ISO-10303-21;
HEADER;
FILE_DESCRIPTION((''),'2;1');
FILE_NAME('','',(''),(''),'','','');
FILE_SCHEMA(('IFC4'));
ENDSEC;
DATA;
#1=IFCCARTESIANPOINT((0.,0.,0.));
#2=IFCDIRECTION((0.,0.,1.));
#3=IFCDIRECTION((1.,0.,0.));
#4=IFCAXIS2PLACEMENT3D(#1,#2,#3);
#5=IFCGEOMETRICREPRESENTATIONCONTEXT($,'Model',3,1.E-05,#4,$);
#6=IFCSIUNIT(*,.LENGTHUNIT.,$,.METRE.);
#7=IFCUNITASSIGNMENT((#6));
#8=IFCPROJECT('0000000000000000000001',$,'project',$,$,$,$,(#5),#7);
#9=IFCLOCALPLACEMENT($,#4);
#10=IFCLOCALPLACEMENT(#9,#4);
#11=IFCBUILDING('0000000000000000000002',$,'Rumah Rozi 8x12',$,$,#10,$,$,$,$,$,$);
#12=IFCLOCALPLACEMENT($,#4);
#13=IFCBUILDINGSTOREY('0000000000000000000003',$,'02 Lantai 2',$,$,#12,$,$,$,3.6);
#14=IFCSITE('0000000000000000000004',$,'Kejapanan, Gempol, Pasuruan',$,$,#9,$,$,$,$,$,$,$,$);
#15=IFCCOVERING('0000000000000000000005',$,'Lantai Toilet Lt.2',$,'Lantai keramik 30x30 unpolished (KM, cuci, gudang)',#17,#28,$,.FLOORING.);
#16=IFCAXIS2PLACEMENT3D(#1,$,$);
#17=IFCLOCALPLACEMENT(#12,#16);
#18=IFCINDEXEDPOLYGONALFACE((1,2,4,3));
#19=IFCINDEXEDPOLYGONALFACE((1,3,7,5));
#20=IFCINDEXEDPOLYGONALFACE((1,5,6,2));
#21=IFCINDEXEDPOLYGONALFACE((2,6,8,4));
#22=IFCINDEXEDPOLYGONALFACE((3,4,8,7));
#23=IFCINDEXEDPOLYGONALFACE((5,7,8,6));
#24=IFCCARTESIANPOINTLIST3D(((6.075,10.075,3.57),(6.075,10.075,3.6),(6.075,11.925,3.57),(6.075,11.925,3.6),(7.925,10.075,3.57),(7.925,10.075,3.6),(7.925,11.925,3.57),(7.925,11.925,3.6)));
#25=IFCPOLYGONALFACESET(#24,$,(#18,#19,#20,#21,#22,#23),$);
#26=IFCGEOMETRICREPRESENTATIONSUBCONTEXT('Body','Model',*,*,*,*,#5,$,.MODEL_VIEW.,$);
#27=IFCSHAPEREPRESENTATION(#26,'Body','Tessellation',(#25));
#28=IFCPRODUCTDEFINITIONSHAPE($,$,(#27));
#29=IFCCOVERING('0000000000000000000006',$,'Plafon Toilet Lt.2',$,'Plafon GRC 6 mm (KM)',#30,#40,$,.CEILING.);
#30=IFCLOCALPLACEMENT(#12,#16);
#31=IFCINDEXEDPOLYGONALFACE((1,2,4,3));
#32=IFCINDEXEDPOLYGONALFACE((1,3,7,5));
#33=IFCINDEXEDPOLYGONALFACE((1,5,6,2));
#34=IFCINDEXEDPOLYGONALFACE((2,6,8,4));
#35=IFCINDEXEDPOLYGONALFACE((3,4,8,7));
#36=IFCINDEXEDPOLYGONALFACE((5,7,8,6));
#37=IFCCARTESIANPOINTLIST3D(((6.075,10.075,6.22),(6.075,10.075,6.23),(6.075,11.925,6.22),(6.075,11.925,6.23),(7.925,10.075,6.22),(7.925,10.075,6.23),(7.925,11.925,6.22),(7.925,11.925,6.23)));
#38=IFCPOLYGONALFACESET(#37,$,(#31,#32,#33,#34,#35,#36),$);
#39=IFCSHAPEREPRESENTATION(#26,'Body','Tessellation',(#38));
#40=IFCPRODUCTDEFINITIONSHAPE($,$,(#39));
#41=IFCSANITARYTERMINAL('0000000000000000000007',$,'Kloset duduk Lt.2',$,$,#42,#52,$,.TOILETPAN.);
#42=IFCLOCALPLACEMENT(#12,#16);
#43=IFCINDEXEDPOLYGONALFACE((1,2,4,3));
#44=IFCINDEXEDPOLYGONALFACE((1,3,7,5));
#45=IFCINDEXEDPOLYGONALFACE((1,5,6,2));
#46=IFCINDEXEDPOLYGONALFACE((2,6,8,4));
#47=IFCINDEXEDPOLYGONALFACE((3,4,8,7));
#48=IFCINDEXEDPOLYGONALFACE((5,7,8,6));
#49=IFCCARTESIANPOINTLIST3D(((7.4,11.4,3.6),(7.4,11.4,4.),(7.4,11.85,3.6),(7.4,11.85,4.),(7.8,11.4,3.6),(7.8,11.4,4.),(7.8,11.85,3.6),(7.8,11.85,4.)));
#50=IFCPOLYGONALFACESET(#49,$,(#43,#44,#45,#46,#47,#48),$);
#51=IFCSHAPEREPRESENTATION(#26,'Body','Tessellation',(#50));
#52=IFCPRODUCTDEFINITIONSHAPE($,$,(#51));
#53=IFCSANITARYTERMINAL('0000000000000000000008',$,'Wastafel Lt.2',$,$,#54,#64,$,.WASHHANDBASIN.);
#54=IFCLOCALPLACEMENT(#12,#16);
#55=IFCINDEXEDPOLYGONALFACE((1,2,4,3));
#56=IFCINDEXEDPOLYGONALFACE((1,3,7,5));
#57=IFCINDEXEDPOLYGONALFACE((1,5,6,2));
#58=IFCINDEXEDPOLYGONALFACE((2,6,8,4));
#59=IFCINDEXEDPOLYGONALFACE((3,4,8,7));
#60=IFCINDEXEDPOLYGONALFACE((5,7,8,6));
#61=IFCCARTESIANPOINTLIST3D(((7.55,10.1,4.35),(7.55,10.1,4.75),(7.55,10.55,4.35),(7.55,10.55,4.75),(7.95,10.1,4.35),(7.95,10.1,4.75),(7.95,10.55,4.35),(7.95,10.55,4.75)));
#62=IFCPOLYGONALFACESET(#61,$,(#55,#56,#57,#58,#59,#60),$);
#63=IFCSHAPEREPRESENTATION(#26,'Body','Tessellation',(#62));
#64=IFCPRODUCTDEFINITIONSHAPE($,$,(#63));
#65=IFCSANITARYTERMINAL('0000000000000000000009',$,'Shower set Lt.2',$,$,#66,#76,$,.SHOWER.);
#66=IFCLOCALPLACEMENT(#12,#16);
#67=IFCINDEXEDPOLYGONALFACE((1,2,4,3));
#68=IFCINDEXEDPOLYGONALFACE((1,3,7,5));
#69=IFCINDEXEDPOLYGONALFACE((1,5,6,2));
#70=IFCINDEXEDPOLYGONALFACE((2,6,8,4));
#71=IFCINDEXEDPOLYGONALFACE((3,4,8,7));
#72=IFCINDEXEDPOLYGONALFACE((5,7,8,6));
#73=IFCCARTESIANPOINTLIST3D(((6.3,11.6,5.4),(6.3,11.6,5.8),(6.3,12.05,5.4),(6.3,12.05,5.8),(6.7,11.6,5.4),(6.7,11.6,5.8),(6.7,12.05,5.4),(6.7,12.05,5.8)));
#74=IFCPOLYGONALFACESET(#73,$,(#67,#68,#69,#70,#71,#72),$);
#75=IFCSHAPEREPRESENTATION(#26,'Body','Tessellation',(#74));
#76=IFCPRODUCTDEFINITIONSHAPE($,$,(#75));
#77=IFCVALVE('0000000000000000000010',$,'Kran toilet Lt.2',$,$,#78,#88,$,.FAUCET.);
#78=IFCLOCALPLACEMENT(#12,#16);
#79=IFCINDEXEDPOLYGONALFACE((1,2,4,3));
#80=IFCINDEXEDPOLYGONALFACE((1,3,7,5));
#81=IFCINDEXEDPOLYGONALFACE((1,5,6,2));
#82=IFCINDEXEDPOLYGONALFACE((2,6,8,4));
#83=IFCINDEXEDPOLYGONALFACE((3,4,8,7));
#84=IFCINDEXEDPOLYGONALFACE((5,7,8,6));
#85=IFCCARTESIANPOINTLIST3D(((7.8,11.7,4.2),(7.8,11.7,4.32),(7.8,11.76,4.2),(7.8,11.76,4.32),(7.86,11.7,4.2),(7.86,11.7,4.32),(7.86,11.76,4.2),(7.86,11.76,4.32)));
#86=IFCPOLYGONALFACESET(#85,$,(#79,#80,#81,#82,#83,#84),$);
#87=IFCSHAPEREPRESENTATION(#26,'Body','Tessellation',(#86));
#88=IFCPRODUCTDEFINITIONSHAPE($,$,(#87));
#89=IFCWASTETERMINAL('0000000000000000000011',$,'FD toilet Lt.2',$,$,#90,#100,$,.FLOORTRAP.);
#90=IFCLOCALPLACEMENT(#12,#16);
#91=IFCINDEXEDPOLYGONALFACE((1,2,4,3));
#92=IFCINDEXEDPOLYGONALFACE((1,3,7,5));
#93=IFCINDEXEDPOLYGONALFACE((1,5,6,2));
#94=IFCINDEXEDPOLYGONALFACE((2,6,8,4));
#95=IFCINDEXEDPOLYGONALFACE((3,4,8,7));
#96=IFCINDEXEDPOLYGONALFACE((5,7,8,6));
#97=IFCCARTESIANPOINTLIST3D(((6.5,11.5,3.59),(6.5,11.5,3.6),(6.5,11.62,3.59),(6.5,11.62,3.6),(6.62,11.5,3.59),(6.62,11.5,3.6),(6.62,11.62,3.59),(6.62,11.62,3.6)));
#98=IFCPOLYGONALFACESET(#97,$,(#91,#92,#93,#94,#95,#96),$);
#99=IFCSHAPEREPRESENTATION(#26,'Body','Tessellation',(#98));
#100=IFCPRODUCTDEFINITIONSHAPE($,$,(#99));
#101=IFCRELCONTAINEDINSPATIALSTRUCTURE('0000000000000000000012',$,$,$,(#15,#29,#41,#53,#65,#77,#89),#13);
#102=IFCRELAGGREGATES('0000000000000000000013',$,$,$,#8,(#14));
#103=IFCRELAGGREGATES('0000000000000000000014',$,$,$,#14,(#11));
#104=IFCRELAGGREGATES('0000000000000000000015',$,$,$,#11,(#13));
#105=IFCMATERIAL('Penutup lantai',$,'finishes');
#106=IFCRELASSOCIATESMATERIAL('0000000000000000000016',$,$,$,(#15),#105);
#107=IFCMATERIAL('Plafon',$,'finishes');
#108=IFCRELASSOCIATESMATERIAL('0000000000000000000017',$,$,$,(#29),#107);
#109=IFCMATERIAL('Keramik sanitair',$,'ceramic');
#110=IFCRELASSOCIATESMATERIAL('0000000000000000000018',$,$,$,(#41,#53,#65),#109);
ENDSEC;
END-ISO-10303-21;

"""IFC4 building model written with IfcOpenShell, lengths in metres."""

from ifc_helpers import new_model, si_unit, frame, origin_with_axes, place, context, subcontext, project, spatial, line, indexed_curve, outline, extrude, material, element, save


model = new_model("IFC4")

# Units and contexts
model_context = context("Model", 3, precision=1e-05, world=origin_with_axes())
body_context = subcontext(model_context, "Body", "Model", "MODEL_VIEW")
ifc_project = project(units=[si_unit("LENGTHUNIT", "METRE")], contexts=[model_context])

# Site, building, storey
site_placement = place(None, origin_with_axes())
site = spatial("IfcSite", under=ifc_project, at=site_placement, Name="Kejapanan, Gempol, Pasuruan")
building_placement = place(site_placement, origin_with_axes())
building = spatial("IfcBuilding", under=site, at=building_placement, Name="Rumah Rozi 8x12")
storey_placement = place(None, origin_with_axes())
storey = spatial("IfcBuildingStorey", under=building, at=storey_placement, Name="02 Lantai 2", Elevation=3.6)

# Coverings
ifc_material_1 = material(Name="Plafon", Category="finishes")
ifc_material_2 = material(Name="Penutup lantai", Category="finishes")
covering_1_placement = place(storey_placement, origin_with_axes())
element("IfcCovering", 1, at=covering_1_placement, inside=storey, material=ifc_material_2, Name="Lantai Toilet Lt.2", ObjectType="Lantai keramik 30x30 unpolished (KM, cuci, gudang)", PredefinedType="FLOORING", context=body_context, shape_type="SweptSolid", body=[
    extrude(outline(indexed_curve([(6.075, 10.075), (7.925, 10.075), (7.925, 11.925), (6.075, 11.925)], segments=[line(1, 2, 3, 4, 1)])), frame((0.0, 0.0, 3.57), z_axis=(0.0, 0.0, 1.0), x_axis=(1.0, 0.0, 0.0)), (0.0, 0.0, 1.0), 0.03),
])
covering_2_placement = place(storey_placement, origin_with_axes())
element("IfcCovering", 2, at=covering_2_placement, inside=storey, material=ifc_material_1, Name="Plafon Toilet Lt.2", ObjectType="Plafon GRC 6 mm (KM)", PredefinedType="CEILING", context=body_context, shape_type="SweptSolid", body=[
    extrude(outline(indexed_curve([(6.075, 10.075), (7.925, 10.075), (7.925, 11.925), (6.075, 11.925)], segments=[line(1, 2, 3, 4, 1)])), frame((0.0, 0.0, 6.22), z_axis=(0.0, 0.0, 1.0), x_axis=(1.0, 0.0, 0.0)), (0.0, 0.0, 1.0), 0.01),
])

# Sanitary terminals
ifc_material_3 = material(Name="Keramik sanitair", Category="ceramic")
sanitary_terminal_1_placement = place(storey_placement, origin_with_axes())
element("IfcSanitaryTerminal", 3, at=sanitary_terminal_1_placement, inside=storey, material=ifc_material_3, Name="Kloset duduk Lt.2", PredefinedType="TOILETPAN", context=body_context, shape_type="SweptSolid", body=[
    extrude(outline(indexed_curve([(7.4, 11.4), (7.8, 11.4), (7.8, 11.85), (7.4, 11.85)], segments=[line(1, 2, 3, 4, 1)])), frame((0.0, 0.0, 3.6), z_axis=(0.0, 0.0, 1.0), x_axis=(1.0, 0.0, 0.0)), (0.0, 0.0, 1.0), 0.4),
])
sanitary_terminal_2_placement = place(storey_placement, origin_with_axes())
element("IfcSanitaryTerminal", 4, at=sanitary_terminal_2_placement, inside=storey, material=ifc_material_3, Name="Wastafel Lt.2", PredefinedType="WASHHANDBASIN", context=body_context, shape_type="SweptSolid", body=[
    extrude(outline(indexed_curve([(7.55, 10.1), (7.95, 10.1), (7.95, 10.55), (7.55, 10.55)], segments=[line(1, 2, 3, 4, 1)])), frame((0.0, 0.0, 4.35), z_axis=(0.0, 0.0, 1.0), x_axis=(1.0, 0.0, 0.0)), (0.0, 0.0, 1.0), 0.4),
])
sanitary_terminal_3_placement = place(storey_placement, origin_with_axes())
element("IfcSanitaryTerminal", 5, at=sanitary_terminal_3_placement, inside=storey, material=ifc_material_3, Name="Shower set Lt.2", PredefinedType="SHOWER", context=body_context, shape_type="SweptSolid", body=[
    extrude(outline(indexed_curve([(6.3, 11.6), (6.7, 11.6), (6.7, 12.05), (6.3, 12.05)], segments=[line(1, 2, 3, 4, 1)])), frame((0.0, 0.0, 5.4), z_axis=(0.0, 0.0, 1.0), x_axis=(1.0, 0.0, 0.0)), (0.0, 0.0, 1.0), 0.4),
])

# Valve
valve_placement = place(storey_placement, origin_with_axes())
element("IfcValve", 6, at=valve_placement, inside=storey, Name="Kran toilet Lt.2", PredefinedType="FAUCET", context=body_context, shape_type="SweptSolid", body=[
    extrude(outline(indexed_curve([(7.8, 11.7), (7.86, 11.7), (7.86, 11.76), (7.8, 11.76)], segments=[line(1, 2, 3, 4, 1)])), frame((0.0, 0.0, 4.2), z_axis=(0.0, 0.0, 1.0), x_axis=(1.0, 0.0, 0.0)), (0.0, 0.0, 1.0), 0.12),
])

# Waste terminal
waste_terminal_placement = place(storey_placement, origin_with_axes())
element("IfcWasteTerminal", 7, at=waste_terminal_placement, inside=storey, Name="FD toilet Lt.2", PredefinedType="FLOORTRAP", context=body_context, shape_type="SweptSolid", body=[
    extrude(outline(indexed_curve([(6.5, 11.5), (6.62, 11.5), (6.62, 11.62), (6.5, 11.62)], segments=[line(1, 2, 3, 4, 1)])), frame((0.0, 0.0, 3.59), z_axis=(0.0, 0.0, 1.0), x_axis=(1.0, 0.0, 0.0)), (0.0, 0.0, 1.0), 0.01),
])

save(model, "model.ifc")
